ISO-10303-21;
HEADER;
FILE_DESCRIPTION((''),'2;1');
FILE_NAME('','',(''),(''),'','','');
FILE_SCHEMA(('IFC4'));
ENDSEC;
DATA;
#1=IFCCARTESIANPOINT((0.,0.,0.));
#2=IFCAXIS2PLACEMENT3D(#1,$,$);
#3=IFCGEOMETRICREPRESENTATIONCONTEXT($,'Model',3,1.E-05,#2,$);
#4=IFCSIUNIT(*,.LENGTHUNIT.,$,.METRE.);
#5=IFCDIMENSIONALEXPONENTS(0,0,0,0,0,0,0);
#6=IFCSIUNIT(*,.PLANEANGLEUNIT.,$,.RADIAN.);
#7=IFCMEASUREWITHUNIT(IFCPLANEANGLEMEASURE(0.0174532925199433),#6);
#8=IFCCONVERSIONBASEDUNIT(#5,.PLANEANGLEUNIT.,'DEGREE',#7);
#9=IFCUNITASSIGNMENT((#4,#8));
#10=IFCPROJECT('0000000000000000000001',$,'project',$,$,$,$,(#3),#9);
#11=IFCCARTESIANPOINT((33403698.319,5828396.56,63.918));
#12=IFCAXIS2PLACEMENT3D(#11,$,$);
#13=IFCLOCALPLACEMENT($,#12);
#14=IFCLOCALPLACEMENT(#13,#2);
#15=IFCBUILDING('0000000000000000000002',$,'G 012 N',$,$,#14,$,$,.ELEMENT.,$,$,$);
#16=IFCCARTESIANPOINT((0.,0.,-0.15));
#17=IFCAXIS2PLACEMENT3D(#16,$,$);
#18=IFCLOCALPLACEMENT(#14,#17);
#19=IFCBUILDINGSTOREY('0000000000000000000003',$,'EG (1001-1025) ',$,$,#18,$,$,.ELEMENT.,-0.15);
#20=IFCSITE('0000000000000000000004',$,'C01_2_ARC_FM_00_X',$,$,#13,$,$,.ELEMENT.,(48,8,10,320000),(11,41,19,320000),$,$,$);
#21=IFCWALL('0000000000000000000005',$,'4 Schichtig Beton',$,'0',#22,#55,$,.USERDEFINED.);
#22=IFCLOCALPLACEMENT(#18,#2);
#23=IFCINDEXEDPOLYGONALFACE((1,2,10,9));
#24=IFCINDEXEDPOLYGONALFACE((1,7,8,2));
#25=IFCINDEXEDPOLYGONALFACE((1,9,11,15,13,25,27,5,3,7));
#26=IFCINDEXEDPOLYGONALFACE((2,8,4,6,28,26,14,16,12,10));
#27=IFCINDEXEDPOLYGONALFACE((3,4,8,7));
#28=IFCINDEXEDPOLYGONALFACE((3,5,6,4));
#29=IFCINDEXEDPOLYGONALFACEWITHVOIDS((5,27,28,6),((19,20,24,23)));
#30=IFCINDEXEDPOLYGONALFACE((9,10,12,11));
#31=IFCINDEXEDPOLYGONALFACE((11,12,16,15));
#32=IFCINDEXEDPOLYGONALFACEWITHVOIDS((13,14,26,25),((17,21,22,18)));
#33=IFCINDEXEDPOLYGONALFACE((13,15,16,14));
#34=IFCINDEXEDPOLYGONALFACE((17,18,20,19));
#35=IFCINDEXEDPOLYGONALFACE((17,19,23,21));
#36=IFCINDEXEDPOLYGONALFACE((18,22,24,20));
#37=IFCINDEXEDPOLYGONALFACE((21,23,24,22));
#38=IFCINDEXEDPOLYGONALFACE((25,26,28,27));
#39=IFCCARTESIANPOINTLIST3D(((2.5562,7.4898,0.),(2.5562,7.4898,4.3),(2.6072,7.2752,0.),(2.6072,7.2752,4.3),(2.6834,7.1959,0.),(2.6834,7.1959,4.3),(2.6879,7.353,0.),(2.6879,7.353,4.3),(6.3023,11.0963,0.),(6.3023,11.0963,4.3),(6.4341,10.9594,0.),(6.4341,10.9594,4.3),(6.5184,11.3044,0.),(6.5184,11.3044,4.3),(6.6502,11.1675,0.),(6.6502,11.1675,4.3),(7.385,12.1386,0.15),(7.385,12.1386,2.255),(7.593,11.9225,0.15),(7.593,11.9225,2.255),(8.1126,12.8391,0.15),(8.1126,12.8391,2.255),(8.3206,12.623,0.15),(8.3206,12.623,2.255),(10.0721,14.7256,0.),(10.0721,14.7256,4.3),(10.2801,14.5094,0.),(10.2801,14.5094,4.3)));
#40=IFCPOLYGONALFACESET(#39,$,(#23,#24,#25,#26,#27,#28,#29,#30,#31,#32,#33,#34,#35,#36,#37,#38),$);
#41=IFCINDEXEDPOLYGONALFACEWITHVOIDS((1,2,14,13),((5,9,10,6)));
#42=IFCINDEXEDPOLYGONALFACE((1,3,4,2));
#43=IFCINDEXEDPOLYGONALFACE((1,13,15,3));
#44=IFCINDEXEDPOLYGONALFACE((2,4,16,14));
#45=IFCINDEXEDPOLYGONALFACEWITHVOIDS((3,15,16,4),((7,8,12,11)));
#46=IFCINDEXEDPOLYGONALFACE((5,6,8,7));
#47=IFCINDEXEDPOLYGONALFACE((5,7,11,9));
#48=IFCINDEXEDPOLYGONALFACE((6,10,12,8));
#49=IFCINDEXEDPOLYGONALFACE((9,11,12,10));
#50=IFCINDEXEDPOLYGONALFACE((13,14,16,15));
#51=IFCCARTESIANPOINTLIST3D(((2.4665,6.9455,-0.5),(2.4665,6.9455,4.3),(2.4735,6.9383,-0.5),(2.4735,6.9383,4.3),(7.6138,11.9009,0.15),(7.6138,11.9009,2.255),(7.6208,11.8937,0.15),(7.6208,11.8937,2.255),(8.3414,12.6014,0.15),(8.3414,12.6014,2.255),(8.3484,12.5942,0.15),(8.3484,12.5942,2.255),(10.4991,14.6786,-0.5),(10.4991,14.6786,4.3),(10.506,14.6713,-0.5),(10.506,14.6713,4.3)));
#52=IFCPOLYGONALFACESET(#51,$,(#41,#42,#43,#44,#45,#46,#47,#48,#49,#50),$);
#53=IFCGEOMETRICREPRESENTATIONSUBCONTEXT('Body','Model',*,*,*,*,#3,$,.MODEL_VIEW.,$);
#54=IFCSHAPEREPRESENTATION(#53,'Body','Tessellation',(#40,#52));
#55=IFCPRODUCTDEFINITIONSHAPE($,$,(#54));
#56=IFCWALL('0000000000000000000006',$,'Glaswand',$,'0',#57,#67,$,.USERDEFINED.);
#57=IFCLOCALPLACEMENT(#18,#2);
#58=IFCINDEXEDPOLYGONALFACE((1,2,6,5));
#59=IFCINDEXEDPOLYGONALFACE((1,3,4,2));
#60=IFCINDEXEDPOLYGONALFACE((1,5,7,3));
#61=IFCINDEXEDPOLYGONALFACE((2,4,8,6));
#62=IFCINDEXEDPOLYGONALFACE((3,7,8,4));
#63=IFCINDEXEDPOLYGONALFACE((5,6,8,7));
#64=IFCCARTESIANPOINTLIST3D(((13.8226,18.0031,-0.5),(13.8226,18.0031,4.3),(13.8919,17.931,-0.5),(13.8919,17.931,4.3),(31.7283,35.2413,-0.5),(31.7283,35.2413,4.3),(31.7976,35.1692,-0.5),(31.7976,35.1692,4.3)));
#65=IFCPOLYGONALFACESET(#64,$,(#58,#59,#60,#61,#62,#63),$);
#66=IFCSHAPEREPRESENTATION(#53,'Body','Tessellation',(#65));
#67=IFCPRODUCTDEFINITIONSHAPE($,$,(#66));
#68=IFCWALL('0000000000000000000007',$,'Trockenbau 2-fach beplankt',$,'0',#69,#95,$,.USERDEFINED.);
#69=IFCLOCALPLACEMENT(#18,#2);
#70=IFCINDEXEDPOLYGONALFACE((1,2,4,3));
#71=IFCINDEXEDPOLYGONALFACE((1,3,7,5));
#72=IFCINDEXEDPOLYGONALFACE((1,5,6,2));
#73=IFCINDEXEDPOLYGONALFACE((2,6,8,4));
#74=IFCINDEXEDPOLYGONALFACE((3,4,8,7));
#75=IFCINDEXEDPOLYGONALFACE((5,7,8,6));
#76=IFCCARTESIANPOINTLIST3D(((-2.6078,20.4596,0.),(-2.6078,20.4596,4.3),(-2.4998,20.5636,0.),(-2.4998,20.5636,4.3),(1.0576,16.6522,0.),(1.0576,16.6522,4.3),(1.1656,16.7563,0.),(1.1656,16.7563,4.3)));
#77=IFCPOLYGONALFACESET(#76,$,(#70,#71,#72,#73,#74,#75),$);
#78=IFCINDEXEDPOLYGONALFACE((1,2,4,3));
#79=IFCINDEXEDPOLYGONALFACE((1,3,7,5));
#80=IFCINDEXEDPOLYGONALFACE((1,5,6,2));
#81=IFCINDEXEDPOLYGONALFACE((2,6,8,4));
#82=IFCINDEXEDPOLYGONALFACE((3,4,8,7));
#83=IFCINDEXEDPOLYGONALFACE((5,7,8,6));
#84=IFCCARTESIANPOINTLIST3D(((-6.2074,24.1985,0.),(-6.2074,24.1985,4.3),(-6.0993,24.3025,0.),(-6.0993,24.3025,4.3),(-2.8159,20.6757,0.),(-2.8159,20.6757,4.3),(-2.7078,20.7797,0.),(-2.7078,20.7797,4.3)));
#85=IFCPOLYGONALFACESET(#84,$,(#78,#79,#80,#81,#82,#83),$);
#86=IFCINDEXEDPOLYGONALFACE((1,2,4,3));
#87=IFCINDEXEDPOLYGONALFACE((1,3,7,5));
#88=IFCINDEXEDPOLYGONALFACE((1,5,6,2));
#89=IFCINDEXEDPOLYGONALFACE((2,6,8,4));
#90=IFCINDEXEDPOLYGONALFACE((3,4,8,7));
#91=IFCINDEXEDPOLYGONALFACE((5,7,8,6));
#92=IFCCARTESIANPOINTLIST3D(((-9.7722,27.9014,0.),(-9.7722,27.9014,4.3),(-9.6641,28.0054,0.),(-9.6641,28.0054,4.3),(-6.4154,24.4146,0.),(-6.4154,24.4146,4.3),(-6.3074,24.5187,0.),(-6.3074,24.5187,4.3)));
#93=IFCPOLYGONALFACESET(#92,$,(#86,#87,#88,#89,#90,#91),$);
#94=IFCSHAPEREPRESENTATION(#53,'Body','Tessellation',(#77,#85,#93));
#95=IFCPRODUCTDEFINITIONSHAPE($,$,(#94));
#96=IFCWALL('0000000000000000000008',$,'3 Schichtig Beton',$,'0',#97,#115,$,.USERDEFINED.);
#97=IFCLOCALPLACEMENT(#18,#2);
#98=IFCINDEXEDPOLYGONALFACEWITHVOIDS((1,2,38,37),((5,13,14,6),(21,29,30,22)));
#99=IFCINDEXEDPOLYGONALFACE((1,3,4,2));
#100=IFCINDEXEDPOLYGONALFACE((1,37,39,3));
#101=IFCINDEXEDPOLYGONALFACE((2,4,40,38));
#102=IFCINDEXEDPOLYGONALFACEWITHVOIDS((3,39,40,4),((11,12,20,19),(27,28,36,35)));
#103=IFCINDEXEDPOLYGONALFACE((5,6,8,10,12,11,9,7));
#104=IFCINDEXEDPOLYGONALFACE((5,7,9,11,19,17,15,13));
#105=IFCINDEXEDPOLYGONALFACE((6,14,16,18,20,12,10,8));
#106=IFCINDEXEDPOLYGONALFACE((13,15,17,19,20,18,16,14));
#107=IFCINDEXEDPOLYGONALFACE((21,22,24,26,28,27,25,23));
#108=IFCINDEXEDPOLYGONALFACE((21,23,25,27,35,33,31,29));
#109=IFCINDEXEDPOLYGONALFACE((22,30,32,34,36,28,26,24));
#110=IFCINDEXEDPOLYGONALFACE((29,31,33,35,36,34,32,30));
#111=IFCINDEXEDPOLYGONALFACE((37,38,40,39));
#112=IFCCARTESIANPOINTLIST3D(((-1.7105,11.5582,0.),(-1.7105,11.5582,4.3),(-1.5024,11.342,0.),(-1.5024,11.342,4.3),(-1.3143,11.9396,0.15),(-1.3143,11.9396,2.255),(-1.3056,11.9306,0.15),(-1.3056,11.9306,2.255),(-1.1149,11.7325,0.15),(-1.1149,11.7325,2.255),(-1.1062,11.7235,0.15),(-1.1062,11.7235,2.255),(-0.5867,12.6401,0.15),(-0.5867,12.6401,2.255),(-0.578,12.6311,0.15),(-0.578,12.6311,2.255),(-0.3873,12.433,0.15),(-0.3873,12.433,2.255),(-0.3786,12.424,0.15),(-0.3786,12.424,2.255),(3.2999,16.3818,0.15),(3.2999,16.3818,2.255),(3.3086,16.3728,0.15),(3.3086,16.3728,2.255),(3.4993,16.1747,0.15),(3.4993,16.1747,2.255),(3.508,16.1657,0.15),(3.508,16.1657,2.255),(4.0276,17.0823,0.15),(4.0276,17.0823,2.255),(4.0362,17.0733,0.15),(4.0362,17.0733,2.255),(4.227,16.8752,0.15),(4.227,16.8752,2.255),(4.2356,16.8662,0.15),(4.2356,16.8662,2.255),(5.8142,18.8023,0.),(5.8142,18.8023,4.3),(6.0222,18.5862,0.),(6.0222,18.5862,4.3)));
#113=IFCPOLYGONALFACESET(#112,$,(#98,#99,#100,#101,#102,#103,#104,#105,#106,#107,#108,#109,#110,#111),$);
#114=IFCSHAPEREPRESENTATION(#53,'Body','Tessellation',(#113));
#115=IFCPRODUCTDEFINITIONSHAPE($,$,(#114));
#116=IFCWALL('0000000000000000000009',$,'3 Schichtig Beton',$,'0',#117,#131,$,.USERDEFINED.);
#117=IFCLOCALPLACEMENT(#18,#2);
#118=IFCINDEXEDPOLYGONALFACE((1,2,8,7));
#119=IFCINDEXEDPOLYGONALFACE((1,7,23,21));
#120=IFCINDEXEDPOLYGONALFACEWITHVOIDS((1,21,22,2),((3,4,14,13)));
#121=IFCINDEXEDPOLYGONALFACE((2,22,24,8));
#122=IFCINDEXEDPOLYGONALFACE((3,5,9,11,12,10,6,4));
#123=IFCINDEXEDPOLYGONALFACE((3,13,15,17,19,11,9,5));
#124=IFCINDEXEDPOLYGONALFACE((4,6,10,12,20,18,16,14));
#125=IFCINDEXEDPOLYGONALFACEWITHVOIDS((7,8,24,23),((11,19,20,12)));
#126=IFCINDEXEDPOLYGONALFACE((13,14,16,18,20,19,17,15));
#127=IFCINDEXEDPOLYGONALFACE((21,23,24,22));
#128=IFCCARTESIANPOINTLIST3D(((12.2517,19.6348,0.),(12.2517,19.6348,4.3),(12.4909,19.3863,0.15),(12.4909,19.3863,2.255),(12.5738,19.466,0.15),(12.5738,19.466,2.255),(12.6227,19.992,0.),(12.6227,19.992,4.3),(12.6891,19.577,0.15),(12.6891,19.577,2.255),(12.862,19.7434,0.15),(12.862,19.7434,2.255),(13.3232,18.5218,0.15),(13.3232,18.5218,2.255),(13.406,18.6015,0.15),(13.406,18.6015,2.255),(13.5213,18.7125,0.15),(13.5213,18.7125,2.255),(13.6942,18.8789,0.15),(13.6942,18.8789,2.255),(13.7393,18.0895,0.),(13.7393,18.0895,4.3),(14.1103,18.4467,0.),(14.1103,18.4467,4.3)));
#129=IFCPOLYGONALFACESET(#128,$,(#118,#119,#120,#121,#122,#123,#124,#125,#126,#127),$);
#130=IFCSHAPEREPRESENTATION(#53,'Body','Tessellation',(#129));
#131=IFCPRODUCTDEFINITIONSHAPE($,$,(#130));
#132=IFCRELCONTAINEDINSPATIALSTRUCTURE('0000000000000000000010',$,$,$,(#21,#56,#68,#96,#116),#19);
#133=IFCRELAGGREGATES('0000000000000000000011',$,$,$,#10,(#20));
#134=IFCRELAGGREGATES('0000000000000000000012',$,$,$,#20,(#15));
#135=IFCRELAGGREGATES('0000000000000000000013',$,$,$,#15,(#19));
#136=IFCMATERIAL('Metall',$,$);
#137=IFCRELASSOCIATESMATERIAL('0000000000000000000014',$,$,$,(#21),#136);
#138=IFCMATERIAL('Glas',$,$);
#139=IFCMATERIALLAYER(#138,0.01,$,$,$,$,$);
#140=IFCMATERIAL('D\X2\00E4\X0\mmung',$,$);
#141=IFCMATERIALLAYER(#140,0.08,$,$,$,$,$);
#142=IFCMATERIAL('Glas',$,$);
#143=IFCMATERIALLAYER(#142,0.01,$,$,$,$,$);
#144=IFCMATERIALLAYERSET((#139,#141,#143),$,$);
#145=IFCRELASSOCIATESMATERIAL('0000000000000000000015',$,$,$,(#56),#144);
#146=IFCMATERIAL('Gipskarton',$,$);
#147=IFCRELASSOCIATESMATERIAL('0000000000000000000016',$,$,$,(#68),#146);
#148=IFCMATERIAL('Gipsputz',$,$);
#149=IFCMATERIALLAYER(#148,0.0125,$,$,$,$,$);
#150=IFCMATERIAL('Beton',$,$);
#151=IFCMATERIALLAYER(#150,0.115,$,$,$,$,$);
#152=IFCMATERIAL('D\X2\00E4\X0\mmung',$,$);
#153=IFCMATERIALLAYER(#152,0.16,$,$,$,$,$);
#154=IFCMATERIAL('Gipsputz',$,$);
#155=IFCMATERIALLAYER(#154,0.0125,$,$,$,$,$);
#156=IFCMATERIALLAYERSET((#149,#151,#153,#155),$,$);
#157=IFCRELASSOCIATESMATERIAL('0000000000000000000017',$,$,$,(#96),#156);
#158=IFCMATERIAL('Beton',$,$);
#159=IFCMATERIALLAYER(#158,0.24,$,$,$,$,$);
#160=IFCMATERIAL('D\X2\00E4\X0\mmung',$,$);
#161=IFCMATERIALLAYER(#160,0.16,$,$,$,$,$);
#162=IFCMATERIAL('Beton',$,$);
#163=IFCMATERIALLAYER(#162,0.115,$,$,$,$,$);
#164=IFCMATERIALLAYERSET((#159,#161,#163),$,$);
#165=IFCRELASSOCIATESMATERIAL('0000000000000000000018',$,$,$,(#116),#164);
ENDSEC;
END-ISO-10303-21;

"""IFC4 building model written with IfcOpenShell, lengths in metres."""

from ifc_helpers import new_model, entity, si_unit, converted_unit, frame, frame_2d, origin, origin_with_axes, place, context, subcontext, project, spatial, polyline, rectangle, outline, extrude, clip, bounded_halfspace, material, layer, layer_set, layer_usage, element, save


model = new_model("IFC4")

# Units and contexts
model_context = context("Model", 3, precision=1e-05, world=origin())
body_context = subcontext(model_context, "Body", "Model", "MODEL_VIEW")
ifc_project = project(units=[si_unit("LENGTHUNIT", "METRE"), converted_unit("PLANEANGLEUNIT", "DEGREE", entity("IfcPlaneAngleMeasure", 0.0174532925199433), si_unit("PLANEANGLEUNIT", "RADIAN"), dimensions=[0, 0, 0, 0, 0, 0, 0])], contexts=[model_context])

# Site, building, storey
site_placement = place(None, frame((33403698.319, 5828396.56, 63.918)))
site = spatial("IfcSite", under=ifc_project, at=site_placement, Name="C01_2_ARC_FM_00_X", CompositionType="ELEMENT", RefLatitude=(48, 8, 10, 320000), RefLongitude=(11, 41, 19, 320000))
building_placement = place(site_placement, origin())
building = spatial("IfcBuilding", under=site, at=building_placement, Name="G 012 N", CompositionType="ELEMENT")
storey_placement = place(building_placement, frame((0.0, 0.0, -0.15)))
storey = spatial("IfcBuildingStorey", under=building, at=storey_placement, Name="EG (1001-1025) ", CompositionType="ELEMENT", Elevation=-0.15)

# Wall, opening
ifc_material_1 = material(Name="Metall")
wall_1_placement = place(storey_placement, frame((2.4735, 6.9383, -0.5), z_axis=(0.0, 0.0, 1.0), x_axis=(0.720408, 0.693551, 0.0)))
wall_1 = element("IfcWall", 1, at=wall_1_placement, inside=storey, material=ifc_material_1, Name="4 Schichtig Beton", ObjectType="0", PredefinedType="USERDEFINED", context=body_context, shape_type="Clipping", body=[
    clip(extrude(outline(polyline([(5.7038, 0.2117), (5.7038, 0.0217), (5.4038, 0.0217), (5.4038, 0.2117), (0.2038, 0.2117), (0.2038, 0.0217), (0.0917, 0.0217), (0.0917, -0.0883), (10.6367, -0.0883), (10.6367, 0.2117), (5.7038, 0.2117)])), frame((0.2383, 0.1283, 0.0), z_axis=(0.0, 0.0, 1.0), x_axis=(1.0, 0.0, 0.0)), (0.0, 0.0, 1.0), 4.8), bounded_halfspace(frame((4.6463, 0.204, 0.5), z_axis=(0.0, 0.0, 1.0), x_axis=(0.0, -1.0, 0.0)), True, origin_with_axes(), polyline([(0.33, 0.15), (0.33, 0.04), (10.875, 0.04), (10.875, 0.34), (5.9421, 0.34), (5.9421, 0.15), (5.6421, 0.15), (5.6421, 0.34), (0.4421, 0.34), (0.4421, 0.15), (0.33, 0.15)]))),
    clip(extrude(rectangle(XDim=11.15, YDim=0.01, at=frame_2d((-5.575, -0.005), x_axis=(-1.0, 0.0))), frame((11.15, 0.01, 0.0), z_axis=(0.0, 0.0, 1.0), x_axis=(1.0, 0.0, 0.0)), (0.0, 0.0, 1.0), 4.8), bounded_halfspace(frame((4.6463, 0.204, 0.5), z_axis=(0.0, 0.0, 1.0), x_axis=(0.0, -1.0, 0.0)), True, origin_with_axes(), polyline([(0.33, 0.15), (0.33, 0.04), (10.875, 0.04), (10.875, 0.34), (5.9421, 0.34), (5.9421, 0.15), (5.6421, 0.15), (5.6421, 0.34), (0.4421, 0.34), (0.4421, 0.15), (0.33, 0.15)]))),
])
opening_1_placement = place(wall_1_placement, frame((8.155, 0.01, 0.65), z_axis=(0.0, -1.0, 0.0), x_axis=(0.0, 0.0, 1.0)))
element("IfcOpeningElement", 2, at=opening_1_placement, cuts=wall_1, ObjectType="Opening", context=body_context, shape_type="SweptSolid", body=[
    extrude(outline(polyline([(0.0, 1.01), (2.105, 1.01), (2.105, 0.0), (0.0, 0.0), (0.0, 1.01)])), origin_with_axes(), (0.0, 0.0, 1.0), 0.01),
    extrude(outline(polyline([(0.0, 1.01), (2.105, 1.01), (2.105, 0.0), (0.0, 0.0), (0.0, 1.01)])), frame((0.0, 0.0, -0.03), z_axis=(0.0, 0.0, 1.0), x_axis=(1.0, 0.0, 0.0)), (0.0, 0.0, 1.0), 0.03),
    extrude(outline(polyline([(0.0, 1.01), (2.105, 1.01), (2.105, 0.0), (0.0, 0.0), (0.0, 1.01)])), frame((0.0, 0.0, -0.33), z_axis=(0.0, 0.0, 1.0), x_axis=(1.0, 0.0, 0.0)), (0.0, 0.0, 1.0), 0.3),
])

# Walls
ifc_material_2 = material(Name="Glas")
ifc_layer_1 = layer(ifc_material_2, 0.01)
ifc_material_3 = material(Name="Dämmung")
ifc_layer_2 = layer(ifc_material_3, 0.08)
ifc_material_4 = material(Name="Glas")
ifc_layer_3 = layer(ifc_material_4, 0.01)
ifc_layer_set_1 = layer_set([ifc_layer_1, ifc_layer_2, ifc_layer_3])
ifc_layer_usage_1 = layer_usage(ifc_layer_set_1, "AXIS2", "POSITIVE", 0.0)
wall_2_placement = place(storey_placement, frame((13.8919, 17.931, -0.5), z_axis=(0.0, 0.0, 1.0), x_axis=(0.720408, 0.693551, 0.0)))
element("IfcWall", 3, at=wall_2_placement, inside=storey, material=ifc_layer_usage_1, Name="Glaswand", ObjectType="0", PredefinedType="USERDEFINED", context=body_context, shape_type="SweptSolid", body=[
    extrude(rectangle(XDim=24.855, YDim=0.1, at=frame_2d((12.4275, 0.05), x_axis=(1.0, 0.0))), origin_with_axes(), (0.0, 0.0, 1.0), 4.8),
])
ifc_material_5 = material(Name="Gipskarton")
wall_3_placement = place(storey_placement, frame((1.1656, 16.7563, 0.0), z_axis=(0.0, 0.0, 1.0), x_axis=(-0.693551, 0.720408, 0.0)))
element("IfcWall", 4, at=wall_3_placement, inside=storey, material=ifc_material_5, Name="Trockenbau 2-fach beplankt", ObjectType="0", PredefinedType="USERDEFINED", context=body_context, shape_type="SweptSolid", body=[
    extrude(rectangle(XDim=0.15, YDim=5.285, at=frame_2d((-2.6425, 0.075), x_axis=(0.0, 1.0))), frame((5.285, 0.0, 0.0), z_axis=(0.0, 0.0, 1.0), x_axis=(1.0, 0.0, 0.0)), (0.0, 0.0, 1.0), 4.3),
    extrude(rectangle(XDim=4.89, YDim=0.15, at=frame_2d((2.445, 0.075), x_axis=(1.0, 0.0))), frame((5.585, 0.0, 0.0), z_axis=(0.0, 0.0, 1.0), x_axis=(1.0, 0.0, 0.0)), (0.0, 0.0, 1.0), 4.3),
    extrude(rectangle(XDim=4.84, YDim=0.15, at=frame_2d((-2.42, -0.075), x_axis=(-1.0, 0.0))), frame((15.615, 0.15, 0.0), z_axis=(0.0, 0.0, 1.0), x_axis=(1.0, 0.0, 0.0)), (0.0, 0.0, 1.0), 4.3),
])

# Wall, openings
ifc_material_6 = material(Name="Gipsputz")
ifc_layer_4 = layer(ifc_material_6, 0.0125)
ifc_material_7 = material(Name="Beton")
ifc_layer_5 = layer(ifc_material_7, 0.115)
ifc_material_8 = material(Name="Dämmung")
ifc_layer_6 = layer(ifc_material_8, 0.16)
ifc_material_9 = material(Name="Gipsputz")
ifc_layer_7 = layer(ifc_material_9, 0.0125)
ifc_layer_set_2 = layer_set([ifc_layer_4, ifc_layer_5, ifc_layer_6, ifc_layer_7])
ifc_layer_usage_2 = layer_usage(ifc_layer_set_2, "AXIS2", "POSITIVE", 0.0)
wall_4_placement = place(storey_placement, frame((5.8142, 18.8023, 0.0), z_axis=(0.0, 0.0, 1.0), x_axis=(-0.720408, -0.693551, 0.0)))
wall_4 = element("IfcWall", 5, at=wall_4_placement, inside=storey, material=ifc_layer_usage_2, Name="3 Schichtig Beton", ObjectType="0", PredefinedType="USERDEFINED", context=body_context, shape_type="SweptSolid", body=[
    extrude(rectangle(XDim=10.445, YDim=0.3, at=frame_2d((5.2225, 0.15), x_axis=(1.0, 0.0))), origin_with_axes(), (0.0, 0.0, 1.0), 4.3),
])
opening_2_placement = place(wall_4_placement, frame((2.48, 0.0, 0.15), z_axis=(0.0, 1.0, 0.0), x_axis=(0.0, 0.0, 1.0)))
element("IfcOpeningElement", 6, at=opening_2_placement, cuts=wall_4, ObjectType="0", PredefinedType="USERDEFINED", context=body_context, shape_type="SweptSolid", body=[
    extrude(outline(polyline([(0.0, 1.01), (2.105, 1.01), (2.105, 0.0), (0.0, 0.0), (0.0, 1.01)])), origin_with_axes(), (0.0, 0.0, 1.0), 0.0125),
    extrude(outline(polyline([(0.0, 1.01), (2.105, 1.01), (2.105, 0.0), (0.0, 0.0), (0.0, 1.01)])), frame((0.0, 0.0, 0.0125), z_axis=(0.0, 0.0, 1.0), x_axis=(1.0, 0.0, 0.0)), (0.0, 0.0, 1.0), 0.115),
    extrude(outline(polyline([(0.0, 1.01), (2.105, 1.01), (2.105, 0.0), (0.0, 0.0), (0.0, 1.01)])), frame((0.0, 0.0, 0.1275), z_axis=(0.0, 0.0, 1.0), x_axis=(1.0, 0.0, 0.0)), (0.0, 0.0, 1.0), 0.16),
    extrude(outline(polyline([(0.0, 1.01), (2.105, 1.01), (2.105, 0.0), (0.0, 0.0), (0.0, 1.01)])), frame((0.0, 0.0, 0.2875), z_axis=(0.0, 0.0, 1.0), x_axis=(1.0, 0.0, 0.0)), (0.0, 0.0, 1.0), 0.0125),
])
opening_3_placement = place(wall_4_placement, frame((8.885, 0.0, 0.15), z_axis=(0.0, 1.0, 0.0), x_axis=(0.0, 0.0, 1.0)))
element("IfcOpeningElement", 7, at=opening_3_placement, cuts=wall_4, ObjectType="0", PredefinedType="USERDEFINED", context=body_context, shape_type="SweptSolid", body=[
    extrude(outline(polyline([(0.0, 1.01), (2.105, 1.01), (2.105, 0.0), (0.0, 0.0), (0.0, 1.01)])), origin_with_axes(), (0.0, 0.0, 1.0), 0.0125),
    extrude(outline(polyline([(0.0, 1.01), (2.105, 1.01), (2.105, 0.0), (0.0, 0.0), (0.0, 1.01)])), frame((0.0, 0.0, 0.0125), z_axis=(0.0, 0.0, 1.0), x_axis=(1.0, 0.0, 0.0)), (0.0, 0.0, 1.0), 0.115),
    extrude(outline(polyline([(0.0, 1.01), (2.105, 1.01), (2.105, 0.0), (0.0, 0.0), (0.0, 1.01)])), frame((0.0, 0.0, 0.1275), z_axis=(0.0, 0.0, 1.0), x_axis=(1.0, 0.0, 0.0)), (0.0, 0.0, 1.0), 0.16),
    extrude(outline(polyline([(0.0, 1.01), (2.105, 1.01), (2.105, 0.0), (0.0, 0.0), (0.0, 1.01)])), frame((0.0, 0.0, 0.2875), z_axis=(0.0, 0.0, 1.0), x_axis=(1.0, 0.0, 0.0)), (0.0, 0.0, 1.0), 0.0125),
])

# Wall, opening
ifc_material_10 = material(Name="Beton")
ifc_layer_8 = layer(ifc_material_10, 0.24)
ifc_material_11 = material(Name="Dämmung")
ifc_layer_9 = layer(ifc_material_11, 0.16)
ifc_material_12 = material(Name="Beton")
ifc_layer_10 = layer(ifc_material_12, 0.115)
ifc_layer_set_3 = layer_set([ifc_layer_8, ifc_layer_9, ifc_layer_10])
ifc_layer_usage_3 = layer_usage(ifc_layer_set_3, "AXIS2", "POSITIVE", 0.0)
wall_5_placement = place(storey_placement, frame((14.1103, 18.4467, 0.0), z_axis=(0.0, 0.0, 1.0), x_axis=(-0.693551, 0.720408, 0.0)))
wall_5 = element("IfcWall", 8, at=wall_5_placement, inside=storey, material=ifc_layer_usage_3, Name="3 Schichtig Beton", ObjectType="0", PredefinedType="USERDEFINED", context=body_context, shape_type="SweptSolid", body=[
    extrude(rectangle(XDim=2.145, YDim=0.515, at=frame_2d((1.0725, 0.2575), x_axis=(1.0, 0.0))), origin_with_axes(), (0.0, 0.0, 1.0), 4.3),
])
opening_4_placement = place(wall_5_placement, frame((1.8, 0.24, 0.15), z_axis=(0.0, -1.0, 0.0), x_axis=(0.0, 0.0, 1.0)))
element("IfcOpeningElement", 9, at=opening_4_placement, cuts=wall_5, ObjectType="0", PredefinedType="USERDEFINED", context=body_context, shape_type="SweptSolid", body=[
    extrude(outline(polyline([(0.0, 1.2), (2.105, 1.2), (2.105, 0.0), (0.0, 0.0), (0.0, 1.2)])), origin_with_axes(), (0.0, 0.0, 1.0), 0.24),
    extrude(outline(polyline([(0.0, 1.2), (2.105, 1.2), (2.105, 0.0), (0.0, 0.0), (0.0, 1.2)])), frame((0.0, 0.0, -0.16), z_axis=(0.0, 0.0, 1.0), x_axis=(1.0, 0.0, 0.0)), (0.0, 0.0, 1.0), 0.16),
    extrude(outline(polyline([(0.0, 1.2), (2.105, 1.2), (2.105, 0.0), (0.0, 0.0), (0.0, 1.2)])), frame((0.0, 0.0, -0.275), z_axis=(0.0, 0.0, 1.0), x_axis=(1.0, 0.0, 0.0)), (0.0, 0.0, 1.0), 0.115),
])

save(model, "model.ifc")
